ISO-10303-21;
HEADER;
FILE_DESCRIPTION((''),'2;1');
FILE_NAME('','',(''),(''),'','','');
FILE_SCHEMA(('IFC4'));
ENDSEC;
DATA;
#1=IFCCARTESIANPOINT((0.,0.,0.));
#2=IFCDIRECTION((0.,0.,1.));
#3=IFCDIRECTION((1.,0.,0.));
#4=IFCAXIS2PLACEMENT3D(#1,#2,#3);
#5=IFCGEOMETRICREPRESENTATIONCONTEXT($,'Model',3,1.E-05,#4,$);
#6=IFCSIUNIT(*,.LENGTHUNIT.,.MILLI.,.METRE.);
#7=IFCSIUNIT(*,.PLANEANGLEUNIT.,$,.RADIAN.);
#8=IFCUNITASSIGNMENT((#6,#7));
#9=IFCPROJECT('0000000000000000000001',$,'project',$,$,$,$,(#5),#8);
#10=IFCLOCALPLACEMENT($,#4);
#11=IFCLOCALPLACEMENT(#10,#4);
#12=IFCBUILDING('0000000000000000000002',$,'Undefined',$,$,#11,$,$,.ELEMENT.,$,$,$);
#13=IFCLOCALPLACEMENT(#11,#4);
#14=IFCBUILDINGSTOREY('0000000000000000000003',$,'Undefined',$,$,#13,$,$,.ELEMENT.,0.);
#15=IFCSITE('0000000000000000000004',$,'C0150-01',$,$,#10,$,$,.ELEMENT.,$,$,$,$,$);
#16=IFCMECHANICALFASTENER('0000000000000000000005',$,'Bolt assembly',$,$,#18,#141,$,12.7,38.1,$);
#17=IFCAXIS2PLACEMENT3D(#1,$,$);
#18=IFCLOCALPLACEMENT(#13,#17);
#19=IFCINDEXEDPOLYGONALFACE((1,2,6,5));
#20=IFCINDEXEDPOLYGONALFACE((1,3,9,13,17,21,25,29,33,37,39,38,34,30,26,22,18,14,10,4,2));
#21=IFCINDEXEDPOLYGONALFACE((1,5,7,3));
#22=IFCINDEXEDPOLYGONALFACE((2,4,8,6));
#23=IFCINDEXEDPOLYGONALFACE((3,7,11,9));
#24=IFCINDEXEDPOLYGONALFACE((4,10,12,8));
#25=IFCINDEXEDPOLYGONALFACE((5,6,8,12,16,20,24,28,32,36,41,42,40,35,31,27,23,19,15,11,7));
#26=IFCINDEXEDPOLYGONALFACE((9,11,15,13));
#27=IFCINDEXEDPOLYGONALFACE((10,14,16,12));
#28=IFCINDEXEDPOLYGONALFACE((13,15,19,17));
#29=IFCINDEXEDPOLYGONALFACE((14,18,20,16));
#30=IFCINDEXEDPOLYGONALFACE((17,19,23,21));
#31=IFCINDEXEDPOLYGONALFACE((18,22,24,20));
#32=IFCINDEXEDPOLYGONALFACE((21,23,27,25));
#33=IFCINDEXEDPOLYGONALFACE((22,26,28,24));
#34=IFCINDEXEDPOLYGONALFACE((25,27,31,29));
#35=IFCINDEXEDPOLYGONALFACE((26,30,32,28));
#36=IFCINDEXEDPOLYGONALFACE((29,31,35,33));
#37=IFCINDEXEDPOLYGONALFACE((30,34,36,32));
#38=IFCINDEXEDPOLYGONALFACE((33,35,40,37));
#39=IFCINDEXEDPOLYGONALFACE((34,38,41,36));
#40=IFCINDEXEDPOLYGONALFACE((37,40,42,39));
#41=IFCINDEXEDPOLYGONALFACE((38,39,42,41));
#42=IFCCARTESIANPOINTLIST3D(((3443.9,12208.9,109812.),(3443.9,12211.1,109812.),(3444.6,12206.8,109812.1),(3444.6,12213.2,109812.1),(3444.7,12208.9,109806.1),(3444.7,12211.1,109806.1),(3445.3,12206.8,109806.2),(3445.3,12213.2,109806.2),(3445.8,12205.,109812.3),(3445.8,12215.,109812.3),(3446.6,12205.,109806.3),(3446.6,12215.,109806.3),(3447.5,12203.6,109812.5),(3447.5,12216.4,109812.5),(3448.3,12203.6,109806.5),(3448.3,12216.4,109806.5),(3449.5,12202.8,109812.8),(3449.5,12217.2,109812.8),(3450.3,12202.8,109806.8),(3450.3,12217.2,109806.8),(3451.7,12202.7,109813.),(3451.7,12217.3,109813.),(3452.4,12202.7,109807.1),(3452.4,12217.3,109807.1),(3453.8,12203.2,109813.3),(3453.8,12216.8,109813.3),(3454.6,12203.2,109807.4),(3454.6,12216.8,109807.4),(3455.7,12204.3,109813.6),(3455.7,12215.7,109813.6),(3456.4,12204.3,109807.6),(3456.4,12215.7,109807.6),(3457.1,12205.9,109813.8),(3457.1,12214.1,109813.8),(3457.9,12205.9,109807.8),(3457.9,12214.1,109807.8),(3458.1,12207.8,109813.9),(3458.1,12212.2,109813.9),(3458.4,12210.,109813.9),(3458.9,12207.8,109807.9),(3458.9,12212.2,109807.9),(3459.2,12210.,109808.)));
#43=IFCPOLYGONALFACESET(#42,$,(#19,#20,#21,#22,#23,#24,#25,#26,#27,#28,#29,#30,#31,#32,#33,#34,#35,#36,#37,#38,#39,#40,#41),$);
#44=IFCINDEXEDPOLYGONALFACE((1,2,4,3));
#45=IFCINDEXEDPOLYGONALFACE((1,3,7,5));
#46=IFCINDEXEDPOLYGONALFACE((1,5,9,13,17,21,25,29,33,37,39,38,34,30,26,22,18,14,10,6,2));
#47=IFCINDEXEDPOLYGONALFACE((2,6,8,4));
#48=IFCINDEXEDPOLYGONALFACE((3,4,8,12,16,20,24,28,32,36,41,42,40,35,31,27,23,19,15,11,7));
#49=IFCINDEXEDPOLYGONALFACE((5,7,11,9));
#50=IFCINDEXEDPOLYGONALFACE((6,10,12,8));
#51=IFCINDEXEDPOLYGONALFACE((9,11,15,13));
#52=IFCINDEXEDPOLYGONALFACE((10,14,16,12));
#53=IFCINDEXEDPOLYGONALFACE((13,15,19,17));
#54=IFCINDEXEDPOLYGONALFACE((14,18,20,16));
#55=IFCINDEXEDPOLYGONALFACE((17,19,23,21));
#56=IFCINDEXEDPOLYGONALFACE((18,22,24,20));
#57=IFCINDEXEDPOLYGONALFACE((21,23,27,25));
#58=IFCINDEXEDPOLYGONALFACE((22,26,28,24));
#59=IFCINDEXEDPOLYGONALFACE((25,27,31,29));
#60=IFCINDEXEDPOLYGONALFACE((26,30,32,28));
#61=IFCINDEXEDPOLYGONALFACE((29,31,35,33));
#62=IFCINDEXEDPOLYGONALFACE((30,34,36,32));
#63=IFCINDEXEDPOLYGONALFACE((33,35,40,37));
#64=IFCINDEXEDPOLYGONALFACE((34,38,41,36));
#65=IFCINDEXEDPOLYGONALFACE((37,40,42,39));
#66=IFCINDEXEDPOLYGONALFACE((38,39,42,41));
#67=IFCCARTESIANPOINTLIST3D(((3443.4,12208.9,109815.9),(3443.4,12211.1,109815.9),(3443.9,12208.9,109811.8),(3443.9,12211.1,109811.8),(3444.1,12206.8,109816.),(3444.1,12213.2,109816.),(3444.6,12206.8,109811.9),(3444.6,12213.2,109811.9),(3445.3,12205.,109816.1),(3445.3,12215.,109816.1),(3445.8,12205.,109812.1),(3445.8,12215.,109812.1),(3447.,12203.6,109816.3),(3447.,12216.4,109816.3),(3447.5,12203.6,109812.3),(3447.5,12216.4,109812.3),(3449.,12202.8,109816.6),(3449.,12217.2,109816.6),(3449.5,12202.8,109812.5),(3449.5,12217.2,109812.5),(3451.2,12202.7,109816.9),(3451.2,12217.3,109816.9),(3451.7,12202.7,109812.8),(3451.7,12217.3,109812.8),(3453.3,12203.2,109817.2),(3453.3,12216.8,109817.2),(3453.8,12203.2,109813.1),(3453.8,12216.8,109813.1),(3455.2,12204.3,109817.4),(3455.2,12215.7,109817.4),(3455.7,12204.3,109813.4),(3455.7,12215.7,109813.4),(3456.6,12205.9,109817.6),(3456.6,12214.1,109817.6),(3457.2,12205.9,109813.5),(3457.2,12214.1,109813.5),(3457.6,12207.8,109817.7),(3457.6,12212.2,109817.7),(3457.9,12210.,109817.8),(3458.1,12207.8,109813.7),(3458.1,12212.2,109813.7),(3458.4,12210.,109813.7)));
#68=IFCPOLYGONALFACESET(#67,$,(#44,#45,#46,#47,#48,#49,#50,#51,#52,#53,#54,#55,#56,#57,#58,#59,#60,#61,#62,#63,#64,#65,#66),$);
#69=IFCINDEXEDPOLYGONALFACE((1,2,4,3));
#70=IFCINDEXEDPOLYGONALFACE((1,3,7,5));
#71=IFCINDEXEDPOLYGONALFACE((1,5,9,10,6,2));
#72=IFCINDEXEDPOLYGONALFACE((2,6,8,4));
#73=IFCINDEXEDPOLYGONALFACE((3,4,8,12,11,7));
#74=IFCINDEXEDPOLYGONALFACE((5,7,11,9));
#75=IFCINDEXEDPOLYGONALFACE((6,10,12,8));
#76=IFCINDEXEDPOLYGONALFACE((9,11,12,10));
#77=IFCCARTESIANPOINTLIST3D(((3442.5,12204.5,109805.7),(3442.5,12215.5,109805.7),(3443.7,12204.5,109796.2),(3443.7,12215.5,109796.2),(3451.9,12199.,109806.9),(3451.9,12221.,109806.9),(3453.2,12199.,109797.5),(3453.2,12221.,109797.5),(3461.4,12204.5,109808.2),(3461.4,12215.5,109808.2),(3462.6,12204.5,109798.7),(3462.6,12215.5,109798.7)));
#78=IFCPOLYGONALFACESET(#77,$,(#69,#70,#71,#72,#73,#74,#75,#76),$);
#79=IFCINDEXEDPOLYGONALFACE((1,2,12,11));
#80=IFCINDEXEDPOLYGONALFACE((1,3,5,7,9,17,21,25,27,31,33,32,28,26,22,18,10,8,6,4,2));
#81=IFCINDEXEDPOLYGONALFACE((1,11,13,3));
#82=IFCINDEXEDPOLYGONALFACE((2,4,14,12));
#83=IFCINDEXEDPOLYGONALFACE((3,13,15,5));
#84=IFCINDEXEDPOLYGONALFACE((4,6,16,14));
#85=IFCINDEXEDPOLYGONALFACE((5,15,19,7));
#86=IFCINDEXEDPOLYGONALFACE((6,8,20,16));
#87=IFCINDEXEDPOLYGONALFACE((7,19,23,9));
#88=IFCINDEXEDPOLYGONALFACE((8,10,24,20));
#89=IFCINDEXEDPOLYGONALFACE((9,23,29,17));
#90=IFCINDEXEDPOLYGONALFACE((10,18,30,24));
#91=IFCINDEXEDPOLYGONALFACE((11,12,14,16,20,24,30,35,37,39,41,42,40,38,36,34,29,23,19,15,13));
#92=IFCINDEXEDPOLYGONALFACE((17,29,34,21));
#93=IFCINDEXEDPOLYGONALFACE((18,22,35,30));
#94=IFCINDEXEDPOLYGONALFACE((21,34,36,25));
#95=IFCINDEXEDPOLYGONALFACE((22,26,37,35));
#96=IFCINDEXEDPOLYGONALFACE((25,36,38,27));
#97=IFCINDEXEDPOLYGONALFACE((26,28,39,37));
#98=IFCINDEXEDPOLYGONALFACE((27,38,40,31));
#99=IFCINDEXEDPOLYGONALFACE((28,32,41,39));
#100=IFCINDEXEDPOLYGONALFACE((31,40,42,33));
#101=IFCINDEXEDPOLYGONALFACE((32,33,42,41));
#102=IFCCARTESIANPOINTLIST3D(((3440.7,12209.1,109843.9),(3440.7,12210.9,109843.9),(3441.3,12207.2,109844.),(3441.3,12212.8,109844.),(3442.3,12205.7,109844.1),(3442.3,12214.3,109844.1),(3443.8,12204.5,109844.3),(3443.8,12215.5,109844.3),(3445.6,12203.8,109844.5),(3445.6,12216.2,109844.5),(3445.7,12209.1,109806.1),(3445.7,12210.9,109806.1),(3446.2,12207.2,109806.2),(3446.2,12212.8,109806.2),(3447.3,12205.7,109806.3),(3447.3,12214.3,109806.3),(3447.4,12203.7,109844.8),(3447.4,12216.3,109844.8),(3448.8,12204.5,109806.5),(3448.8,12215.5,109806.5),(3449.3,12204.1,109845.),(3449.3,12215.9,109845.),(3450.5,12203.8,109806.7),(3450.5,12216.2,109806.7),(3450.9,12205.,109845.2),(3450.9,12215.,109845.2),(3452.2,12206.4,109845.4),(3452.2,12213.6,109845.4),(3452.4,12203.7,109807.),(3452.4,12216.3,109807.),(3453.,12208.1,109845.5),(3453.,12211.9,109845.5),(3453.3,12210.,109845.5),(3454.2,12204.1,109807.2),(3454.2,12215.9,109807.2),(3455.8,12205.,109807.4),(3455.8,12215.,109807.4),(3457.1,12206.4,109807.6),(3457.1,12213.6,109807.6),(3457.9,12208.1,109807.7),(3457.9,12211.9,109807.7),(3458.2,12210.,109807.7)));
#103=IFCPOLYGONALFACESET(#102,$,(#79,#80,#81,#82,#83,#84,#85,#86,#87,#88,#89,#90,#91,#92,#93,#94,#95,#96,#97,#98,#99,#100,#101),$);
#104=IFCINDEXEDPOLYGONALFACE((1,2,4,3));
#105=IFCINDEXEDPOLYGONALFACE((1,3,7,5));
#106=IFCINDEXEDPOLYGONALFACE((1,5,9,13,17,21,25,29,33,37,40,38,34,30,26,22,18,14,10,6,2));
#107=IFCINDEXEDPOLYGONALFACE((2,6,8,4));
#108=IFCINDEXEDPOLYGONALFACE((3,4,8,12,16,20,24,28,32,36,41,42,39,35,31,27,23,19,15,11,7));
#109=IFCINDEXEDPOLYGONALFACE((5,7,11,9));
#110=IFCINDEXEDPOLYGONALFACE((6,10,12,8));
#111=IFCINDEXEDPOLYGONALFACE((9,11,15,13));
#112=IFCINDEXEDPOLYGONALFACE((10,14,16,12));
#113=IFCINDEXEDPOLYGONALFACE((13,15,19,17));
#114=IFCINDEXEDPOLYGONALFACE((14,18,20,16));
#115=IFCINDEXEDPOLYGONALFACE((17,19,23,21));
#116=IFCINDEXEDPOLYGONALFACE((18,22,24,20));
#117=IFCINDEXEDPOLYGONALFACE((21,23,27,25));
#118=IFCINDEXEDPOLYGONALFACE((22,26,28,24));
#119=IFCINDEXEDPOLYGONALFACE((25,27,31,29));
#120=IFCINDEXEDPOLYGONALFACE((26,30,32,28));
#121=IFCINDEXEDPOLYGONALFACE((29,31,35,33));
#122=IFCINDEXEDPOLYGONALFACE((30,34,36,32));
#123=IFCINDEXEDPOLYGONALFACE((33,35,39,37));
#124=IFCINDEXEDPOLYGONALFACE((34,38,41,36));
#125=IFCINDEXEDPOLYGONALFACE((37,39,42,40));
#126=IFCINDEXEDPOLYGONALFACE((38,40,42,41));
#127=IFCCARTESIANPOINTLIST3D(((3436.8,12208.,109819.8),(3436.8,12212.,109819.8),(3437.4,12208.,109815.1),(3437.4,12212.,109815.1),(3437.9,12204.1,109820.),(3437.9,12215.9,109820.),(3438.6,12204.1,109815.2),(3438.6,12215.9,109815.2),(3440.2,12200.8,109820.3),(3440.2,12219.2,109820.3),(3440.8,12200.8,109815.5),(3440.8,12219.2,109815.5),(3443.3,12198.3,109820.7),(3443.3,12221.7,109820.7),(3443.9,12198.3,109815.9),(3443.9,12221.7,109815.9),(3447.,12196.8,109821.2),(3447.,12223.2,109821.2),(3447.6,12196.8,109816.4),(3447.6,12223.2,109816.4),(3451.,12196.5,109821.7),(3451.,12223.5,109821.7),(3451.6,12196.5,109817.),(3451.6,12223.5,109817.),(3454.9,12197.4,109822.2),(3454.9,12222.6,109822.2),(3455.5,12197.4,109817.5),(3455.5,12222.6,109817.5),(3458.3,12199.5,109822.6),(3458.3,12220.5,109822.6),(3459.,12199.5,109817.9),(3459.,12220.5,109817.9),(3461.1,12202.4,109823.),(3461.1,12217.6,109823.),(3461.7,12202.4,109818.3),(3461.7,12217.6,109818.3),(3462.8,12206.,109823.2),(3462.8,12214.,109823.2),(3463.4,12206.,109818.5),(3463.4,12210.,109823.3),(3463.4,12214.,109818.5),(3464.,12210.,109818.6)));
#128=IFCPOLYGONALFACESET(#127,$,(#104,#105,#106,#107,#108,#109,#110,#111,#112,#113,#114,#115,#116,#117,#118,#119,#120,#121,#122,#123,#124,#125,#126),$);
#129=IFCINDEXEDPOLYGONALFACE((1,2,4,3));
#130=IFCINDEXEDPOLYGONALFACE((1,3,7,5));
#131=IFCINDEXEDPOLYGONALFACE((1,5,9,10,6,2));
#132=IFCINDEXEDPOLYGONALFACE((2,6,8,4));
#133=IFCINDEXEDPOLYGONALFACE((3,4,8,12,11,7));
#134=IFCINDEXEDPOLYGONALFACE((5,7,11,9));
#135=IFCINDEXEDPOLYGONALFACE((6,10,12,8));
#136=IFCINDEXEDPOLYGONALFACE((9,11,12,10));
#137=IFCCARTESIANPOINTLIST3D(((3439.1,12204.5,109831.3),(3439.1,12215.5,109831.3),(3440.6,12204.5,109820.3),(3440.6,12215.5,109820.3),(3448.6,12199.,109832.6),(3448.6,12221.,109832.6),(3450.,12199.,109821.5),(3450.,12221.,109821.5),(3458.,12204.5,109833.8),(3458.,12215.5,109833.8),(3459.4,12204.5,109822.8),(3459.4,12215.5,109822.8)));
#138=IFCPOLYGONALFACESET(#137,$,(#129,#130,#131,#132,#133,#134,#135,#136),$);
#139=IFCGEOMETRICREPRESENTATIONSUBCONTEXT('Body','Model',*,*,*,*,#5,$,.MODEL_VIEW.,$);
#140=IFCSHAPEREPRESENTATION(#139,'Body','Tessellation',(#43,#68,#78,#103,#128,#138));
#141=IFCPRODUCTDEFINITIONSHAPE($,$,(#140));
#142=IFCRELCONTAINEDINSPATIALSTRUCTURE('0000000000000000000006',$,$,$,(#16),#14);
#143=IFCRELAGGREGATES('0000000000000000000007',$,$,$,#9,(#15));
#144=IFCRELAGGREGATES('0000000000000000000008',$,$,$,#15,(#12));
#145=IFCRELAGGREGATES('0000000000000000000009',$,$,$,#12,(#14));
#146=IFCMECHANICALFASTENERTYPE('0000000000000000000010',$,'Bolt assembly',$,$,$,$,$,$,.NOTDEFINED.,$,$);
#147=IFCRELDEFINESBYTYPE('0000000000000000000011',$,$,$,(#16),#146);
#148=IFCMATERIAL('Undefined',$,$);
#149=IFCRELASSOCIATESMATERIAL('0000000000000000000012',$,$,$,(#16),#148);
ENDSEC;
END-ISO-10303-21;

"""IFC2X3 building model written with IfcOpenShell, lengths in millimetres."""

from ifc_helpers import new_model, si_unit, frame, origin_with_axes, origin_2d_with_axis, place, context, subcontext, project, spatial, polyline, circle, outline, extrude, source, transform, mapped, material, type_object, element, save


model = new_model("IFC2X3")

# Units and contexts
model_context = context("Model", 3, precision=1e-05, world=origin_with_axes())
body_context = subcontext(model_context, "Body", "Model", "MODEL_VIEW")
ifc_project = project(units=[si_unit("LENGTHUNIT", "METRE", prefix="MILLI"), si_unit("PLANEANGLEUNIT", "RADIAN")], contexts=[model_context])

# Site, building, storey
site_placement = place(None, origin_with_axes())
site = spatial("IfcSite", under=ifc_project, at=site_placement, Name="C0150-01", CompositionType="ELEMENT")
building_placement = place(site_placement, origin_with_axes())
building = spatial("IfcBuilding", under=site, at=building_placement, Name="Undefined", CompositionType="ELEMENT")
storey_placement = place(building_placement, origin_with_axes())
storey = spatial("IfcBuildingStorey", under=building, at=storey_placement, Name="Undefined", CompositionType="ELEMENT", Elevation=0.0)

# Mechanical fastener
ifc_material_1 = material(Name="Undefined")
mechanical_fastener_type = type_object("IfcMechanicalFastenerType", Name="Bolt assembly")
shared_shape_1 = source(origin_with_axes(), body_context, "Body", "SweptSolid", [
    extrude(circle(Radius=7.3, at=origin_2d_with_axis()), frame((0.0, -9.9, 0.0), z_axis=(0.0, 1.0, 0.0), x_axis=(1.0, 0.0, 0.0)), (0.0, 0.0, 1.0), 6.0),
    extrude(circle(Radius=7.3, at=origin_2d_with_axis()), frame((0.0, -4.1, 0.0), z_axis=(0.0, 1.0, 0.0), x_axis=(1.0, 0.0, 0.0)), (0.0, 0.0, 1.0), 4.1),
    extrude(outline(polyline([(9.5, -5.5), (9.5, 5.5), (0.0, 11.0), (-9.5, 5.5), (-9.5, -5.5), (0.0, -11.0), (9.5, -5.5)])), frame((0.0, -19.5, 0.0), z_axis=(0.0, 1.0, 0.0), x_axis=(1.0, 0.0, 0.0)), (0.0, 0.0, 1.0), 9.5),
    extrude(circle(Radius=6.3, at=origin_2d_with_axis()), frame((0.0, -10.0, 0.0), z_axis=(0.0, 1.0, 0.0), x_axis=(1.0, 0.0, 0.0)), (0.0, 0.0, 1.0), 38.1),
    extrude(circle(Radius=13.5, at=origin_2d_with_axis()), frame((0.0, 0.0, 0.0), z_axis=(0.0, 1.0, 0.0), x_axis=(1.0, 0.0, 0.0)), (0.0, 0.0, 1.0), 4.8),
    extrude(outline(polyline([(9.5, -5.5), (9.5, 5.5), (0.0, 11.0), (-9.5, 5.5), (-9.5, -5.5), (0.0, -11.0), (9.5, -5.5)])), frame((0.0, 4.8, 0.0), z_axis=(0.0, 1.0, 0.0), x_axis=(1.0, 0.0, 0.0)), (0.0, 0.0, 1.0), 11.1),
])
for number, where, z_axis, x_axis, name in (
    (1, (3450.6, 12210.0, 109816.8), (0.0, -1.0, 0.0), (0.991507, 0.0, 0.130054), "Bolt assembly"),
):
    element("IfcMechanicalFastener", number, at=place(storey_placement, frame(where, z_axis=z_axis, x_axis=x_axis)), inside=storey, type_object=mechanical_fastener_type, material=ifc_material_1, Name=name, NominalDiameter=12.7, NominalLength=38.1, context=body_context, shape_type="MappedRepresentation", body=[
        mapped(shared_shape_1, transform((0.0, 0.0, 0.0))),
    ])

save(model, "model.ifc")
